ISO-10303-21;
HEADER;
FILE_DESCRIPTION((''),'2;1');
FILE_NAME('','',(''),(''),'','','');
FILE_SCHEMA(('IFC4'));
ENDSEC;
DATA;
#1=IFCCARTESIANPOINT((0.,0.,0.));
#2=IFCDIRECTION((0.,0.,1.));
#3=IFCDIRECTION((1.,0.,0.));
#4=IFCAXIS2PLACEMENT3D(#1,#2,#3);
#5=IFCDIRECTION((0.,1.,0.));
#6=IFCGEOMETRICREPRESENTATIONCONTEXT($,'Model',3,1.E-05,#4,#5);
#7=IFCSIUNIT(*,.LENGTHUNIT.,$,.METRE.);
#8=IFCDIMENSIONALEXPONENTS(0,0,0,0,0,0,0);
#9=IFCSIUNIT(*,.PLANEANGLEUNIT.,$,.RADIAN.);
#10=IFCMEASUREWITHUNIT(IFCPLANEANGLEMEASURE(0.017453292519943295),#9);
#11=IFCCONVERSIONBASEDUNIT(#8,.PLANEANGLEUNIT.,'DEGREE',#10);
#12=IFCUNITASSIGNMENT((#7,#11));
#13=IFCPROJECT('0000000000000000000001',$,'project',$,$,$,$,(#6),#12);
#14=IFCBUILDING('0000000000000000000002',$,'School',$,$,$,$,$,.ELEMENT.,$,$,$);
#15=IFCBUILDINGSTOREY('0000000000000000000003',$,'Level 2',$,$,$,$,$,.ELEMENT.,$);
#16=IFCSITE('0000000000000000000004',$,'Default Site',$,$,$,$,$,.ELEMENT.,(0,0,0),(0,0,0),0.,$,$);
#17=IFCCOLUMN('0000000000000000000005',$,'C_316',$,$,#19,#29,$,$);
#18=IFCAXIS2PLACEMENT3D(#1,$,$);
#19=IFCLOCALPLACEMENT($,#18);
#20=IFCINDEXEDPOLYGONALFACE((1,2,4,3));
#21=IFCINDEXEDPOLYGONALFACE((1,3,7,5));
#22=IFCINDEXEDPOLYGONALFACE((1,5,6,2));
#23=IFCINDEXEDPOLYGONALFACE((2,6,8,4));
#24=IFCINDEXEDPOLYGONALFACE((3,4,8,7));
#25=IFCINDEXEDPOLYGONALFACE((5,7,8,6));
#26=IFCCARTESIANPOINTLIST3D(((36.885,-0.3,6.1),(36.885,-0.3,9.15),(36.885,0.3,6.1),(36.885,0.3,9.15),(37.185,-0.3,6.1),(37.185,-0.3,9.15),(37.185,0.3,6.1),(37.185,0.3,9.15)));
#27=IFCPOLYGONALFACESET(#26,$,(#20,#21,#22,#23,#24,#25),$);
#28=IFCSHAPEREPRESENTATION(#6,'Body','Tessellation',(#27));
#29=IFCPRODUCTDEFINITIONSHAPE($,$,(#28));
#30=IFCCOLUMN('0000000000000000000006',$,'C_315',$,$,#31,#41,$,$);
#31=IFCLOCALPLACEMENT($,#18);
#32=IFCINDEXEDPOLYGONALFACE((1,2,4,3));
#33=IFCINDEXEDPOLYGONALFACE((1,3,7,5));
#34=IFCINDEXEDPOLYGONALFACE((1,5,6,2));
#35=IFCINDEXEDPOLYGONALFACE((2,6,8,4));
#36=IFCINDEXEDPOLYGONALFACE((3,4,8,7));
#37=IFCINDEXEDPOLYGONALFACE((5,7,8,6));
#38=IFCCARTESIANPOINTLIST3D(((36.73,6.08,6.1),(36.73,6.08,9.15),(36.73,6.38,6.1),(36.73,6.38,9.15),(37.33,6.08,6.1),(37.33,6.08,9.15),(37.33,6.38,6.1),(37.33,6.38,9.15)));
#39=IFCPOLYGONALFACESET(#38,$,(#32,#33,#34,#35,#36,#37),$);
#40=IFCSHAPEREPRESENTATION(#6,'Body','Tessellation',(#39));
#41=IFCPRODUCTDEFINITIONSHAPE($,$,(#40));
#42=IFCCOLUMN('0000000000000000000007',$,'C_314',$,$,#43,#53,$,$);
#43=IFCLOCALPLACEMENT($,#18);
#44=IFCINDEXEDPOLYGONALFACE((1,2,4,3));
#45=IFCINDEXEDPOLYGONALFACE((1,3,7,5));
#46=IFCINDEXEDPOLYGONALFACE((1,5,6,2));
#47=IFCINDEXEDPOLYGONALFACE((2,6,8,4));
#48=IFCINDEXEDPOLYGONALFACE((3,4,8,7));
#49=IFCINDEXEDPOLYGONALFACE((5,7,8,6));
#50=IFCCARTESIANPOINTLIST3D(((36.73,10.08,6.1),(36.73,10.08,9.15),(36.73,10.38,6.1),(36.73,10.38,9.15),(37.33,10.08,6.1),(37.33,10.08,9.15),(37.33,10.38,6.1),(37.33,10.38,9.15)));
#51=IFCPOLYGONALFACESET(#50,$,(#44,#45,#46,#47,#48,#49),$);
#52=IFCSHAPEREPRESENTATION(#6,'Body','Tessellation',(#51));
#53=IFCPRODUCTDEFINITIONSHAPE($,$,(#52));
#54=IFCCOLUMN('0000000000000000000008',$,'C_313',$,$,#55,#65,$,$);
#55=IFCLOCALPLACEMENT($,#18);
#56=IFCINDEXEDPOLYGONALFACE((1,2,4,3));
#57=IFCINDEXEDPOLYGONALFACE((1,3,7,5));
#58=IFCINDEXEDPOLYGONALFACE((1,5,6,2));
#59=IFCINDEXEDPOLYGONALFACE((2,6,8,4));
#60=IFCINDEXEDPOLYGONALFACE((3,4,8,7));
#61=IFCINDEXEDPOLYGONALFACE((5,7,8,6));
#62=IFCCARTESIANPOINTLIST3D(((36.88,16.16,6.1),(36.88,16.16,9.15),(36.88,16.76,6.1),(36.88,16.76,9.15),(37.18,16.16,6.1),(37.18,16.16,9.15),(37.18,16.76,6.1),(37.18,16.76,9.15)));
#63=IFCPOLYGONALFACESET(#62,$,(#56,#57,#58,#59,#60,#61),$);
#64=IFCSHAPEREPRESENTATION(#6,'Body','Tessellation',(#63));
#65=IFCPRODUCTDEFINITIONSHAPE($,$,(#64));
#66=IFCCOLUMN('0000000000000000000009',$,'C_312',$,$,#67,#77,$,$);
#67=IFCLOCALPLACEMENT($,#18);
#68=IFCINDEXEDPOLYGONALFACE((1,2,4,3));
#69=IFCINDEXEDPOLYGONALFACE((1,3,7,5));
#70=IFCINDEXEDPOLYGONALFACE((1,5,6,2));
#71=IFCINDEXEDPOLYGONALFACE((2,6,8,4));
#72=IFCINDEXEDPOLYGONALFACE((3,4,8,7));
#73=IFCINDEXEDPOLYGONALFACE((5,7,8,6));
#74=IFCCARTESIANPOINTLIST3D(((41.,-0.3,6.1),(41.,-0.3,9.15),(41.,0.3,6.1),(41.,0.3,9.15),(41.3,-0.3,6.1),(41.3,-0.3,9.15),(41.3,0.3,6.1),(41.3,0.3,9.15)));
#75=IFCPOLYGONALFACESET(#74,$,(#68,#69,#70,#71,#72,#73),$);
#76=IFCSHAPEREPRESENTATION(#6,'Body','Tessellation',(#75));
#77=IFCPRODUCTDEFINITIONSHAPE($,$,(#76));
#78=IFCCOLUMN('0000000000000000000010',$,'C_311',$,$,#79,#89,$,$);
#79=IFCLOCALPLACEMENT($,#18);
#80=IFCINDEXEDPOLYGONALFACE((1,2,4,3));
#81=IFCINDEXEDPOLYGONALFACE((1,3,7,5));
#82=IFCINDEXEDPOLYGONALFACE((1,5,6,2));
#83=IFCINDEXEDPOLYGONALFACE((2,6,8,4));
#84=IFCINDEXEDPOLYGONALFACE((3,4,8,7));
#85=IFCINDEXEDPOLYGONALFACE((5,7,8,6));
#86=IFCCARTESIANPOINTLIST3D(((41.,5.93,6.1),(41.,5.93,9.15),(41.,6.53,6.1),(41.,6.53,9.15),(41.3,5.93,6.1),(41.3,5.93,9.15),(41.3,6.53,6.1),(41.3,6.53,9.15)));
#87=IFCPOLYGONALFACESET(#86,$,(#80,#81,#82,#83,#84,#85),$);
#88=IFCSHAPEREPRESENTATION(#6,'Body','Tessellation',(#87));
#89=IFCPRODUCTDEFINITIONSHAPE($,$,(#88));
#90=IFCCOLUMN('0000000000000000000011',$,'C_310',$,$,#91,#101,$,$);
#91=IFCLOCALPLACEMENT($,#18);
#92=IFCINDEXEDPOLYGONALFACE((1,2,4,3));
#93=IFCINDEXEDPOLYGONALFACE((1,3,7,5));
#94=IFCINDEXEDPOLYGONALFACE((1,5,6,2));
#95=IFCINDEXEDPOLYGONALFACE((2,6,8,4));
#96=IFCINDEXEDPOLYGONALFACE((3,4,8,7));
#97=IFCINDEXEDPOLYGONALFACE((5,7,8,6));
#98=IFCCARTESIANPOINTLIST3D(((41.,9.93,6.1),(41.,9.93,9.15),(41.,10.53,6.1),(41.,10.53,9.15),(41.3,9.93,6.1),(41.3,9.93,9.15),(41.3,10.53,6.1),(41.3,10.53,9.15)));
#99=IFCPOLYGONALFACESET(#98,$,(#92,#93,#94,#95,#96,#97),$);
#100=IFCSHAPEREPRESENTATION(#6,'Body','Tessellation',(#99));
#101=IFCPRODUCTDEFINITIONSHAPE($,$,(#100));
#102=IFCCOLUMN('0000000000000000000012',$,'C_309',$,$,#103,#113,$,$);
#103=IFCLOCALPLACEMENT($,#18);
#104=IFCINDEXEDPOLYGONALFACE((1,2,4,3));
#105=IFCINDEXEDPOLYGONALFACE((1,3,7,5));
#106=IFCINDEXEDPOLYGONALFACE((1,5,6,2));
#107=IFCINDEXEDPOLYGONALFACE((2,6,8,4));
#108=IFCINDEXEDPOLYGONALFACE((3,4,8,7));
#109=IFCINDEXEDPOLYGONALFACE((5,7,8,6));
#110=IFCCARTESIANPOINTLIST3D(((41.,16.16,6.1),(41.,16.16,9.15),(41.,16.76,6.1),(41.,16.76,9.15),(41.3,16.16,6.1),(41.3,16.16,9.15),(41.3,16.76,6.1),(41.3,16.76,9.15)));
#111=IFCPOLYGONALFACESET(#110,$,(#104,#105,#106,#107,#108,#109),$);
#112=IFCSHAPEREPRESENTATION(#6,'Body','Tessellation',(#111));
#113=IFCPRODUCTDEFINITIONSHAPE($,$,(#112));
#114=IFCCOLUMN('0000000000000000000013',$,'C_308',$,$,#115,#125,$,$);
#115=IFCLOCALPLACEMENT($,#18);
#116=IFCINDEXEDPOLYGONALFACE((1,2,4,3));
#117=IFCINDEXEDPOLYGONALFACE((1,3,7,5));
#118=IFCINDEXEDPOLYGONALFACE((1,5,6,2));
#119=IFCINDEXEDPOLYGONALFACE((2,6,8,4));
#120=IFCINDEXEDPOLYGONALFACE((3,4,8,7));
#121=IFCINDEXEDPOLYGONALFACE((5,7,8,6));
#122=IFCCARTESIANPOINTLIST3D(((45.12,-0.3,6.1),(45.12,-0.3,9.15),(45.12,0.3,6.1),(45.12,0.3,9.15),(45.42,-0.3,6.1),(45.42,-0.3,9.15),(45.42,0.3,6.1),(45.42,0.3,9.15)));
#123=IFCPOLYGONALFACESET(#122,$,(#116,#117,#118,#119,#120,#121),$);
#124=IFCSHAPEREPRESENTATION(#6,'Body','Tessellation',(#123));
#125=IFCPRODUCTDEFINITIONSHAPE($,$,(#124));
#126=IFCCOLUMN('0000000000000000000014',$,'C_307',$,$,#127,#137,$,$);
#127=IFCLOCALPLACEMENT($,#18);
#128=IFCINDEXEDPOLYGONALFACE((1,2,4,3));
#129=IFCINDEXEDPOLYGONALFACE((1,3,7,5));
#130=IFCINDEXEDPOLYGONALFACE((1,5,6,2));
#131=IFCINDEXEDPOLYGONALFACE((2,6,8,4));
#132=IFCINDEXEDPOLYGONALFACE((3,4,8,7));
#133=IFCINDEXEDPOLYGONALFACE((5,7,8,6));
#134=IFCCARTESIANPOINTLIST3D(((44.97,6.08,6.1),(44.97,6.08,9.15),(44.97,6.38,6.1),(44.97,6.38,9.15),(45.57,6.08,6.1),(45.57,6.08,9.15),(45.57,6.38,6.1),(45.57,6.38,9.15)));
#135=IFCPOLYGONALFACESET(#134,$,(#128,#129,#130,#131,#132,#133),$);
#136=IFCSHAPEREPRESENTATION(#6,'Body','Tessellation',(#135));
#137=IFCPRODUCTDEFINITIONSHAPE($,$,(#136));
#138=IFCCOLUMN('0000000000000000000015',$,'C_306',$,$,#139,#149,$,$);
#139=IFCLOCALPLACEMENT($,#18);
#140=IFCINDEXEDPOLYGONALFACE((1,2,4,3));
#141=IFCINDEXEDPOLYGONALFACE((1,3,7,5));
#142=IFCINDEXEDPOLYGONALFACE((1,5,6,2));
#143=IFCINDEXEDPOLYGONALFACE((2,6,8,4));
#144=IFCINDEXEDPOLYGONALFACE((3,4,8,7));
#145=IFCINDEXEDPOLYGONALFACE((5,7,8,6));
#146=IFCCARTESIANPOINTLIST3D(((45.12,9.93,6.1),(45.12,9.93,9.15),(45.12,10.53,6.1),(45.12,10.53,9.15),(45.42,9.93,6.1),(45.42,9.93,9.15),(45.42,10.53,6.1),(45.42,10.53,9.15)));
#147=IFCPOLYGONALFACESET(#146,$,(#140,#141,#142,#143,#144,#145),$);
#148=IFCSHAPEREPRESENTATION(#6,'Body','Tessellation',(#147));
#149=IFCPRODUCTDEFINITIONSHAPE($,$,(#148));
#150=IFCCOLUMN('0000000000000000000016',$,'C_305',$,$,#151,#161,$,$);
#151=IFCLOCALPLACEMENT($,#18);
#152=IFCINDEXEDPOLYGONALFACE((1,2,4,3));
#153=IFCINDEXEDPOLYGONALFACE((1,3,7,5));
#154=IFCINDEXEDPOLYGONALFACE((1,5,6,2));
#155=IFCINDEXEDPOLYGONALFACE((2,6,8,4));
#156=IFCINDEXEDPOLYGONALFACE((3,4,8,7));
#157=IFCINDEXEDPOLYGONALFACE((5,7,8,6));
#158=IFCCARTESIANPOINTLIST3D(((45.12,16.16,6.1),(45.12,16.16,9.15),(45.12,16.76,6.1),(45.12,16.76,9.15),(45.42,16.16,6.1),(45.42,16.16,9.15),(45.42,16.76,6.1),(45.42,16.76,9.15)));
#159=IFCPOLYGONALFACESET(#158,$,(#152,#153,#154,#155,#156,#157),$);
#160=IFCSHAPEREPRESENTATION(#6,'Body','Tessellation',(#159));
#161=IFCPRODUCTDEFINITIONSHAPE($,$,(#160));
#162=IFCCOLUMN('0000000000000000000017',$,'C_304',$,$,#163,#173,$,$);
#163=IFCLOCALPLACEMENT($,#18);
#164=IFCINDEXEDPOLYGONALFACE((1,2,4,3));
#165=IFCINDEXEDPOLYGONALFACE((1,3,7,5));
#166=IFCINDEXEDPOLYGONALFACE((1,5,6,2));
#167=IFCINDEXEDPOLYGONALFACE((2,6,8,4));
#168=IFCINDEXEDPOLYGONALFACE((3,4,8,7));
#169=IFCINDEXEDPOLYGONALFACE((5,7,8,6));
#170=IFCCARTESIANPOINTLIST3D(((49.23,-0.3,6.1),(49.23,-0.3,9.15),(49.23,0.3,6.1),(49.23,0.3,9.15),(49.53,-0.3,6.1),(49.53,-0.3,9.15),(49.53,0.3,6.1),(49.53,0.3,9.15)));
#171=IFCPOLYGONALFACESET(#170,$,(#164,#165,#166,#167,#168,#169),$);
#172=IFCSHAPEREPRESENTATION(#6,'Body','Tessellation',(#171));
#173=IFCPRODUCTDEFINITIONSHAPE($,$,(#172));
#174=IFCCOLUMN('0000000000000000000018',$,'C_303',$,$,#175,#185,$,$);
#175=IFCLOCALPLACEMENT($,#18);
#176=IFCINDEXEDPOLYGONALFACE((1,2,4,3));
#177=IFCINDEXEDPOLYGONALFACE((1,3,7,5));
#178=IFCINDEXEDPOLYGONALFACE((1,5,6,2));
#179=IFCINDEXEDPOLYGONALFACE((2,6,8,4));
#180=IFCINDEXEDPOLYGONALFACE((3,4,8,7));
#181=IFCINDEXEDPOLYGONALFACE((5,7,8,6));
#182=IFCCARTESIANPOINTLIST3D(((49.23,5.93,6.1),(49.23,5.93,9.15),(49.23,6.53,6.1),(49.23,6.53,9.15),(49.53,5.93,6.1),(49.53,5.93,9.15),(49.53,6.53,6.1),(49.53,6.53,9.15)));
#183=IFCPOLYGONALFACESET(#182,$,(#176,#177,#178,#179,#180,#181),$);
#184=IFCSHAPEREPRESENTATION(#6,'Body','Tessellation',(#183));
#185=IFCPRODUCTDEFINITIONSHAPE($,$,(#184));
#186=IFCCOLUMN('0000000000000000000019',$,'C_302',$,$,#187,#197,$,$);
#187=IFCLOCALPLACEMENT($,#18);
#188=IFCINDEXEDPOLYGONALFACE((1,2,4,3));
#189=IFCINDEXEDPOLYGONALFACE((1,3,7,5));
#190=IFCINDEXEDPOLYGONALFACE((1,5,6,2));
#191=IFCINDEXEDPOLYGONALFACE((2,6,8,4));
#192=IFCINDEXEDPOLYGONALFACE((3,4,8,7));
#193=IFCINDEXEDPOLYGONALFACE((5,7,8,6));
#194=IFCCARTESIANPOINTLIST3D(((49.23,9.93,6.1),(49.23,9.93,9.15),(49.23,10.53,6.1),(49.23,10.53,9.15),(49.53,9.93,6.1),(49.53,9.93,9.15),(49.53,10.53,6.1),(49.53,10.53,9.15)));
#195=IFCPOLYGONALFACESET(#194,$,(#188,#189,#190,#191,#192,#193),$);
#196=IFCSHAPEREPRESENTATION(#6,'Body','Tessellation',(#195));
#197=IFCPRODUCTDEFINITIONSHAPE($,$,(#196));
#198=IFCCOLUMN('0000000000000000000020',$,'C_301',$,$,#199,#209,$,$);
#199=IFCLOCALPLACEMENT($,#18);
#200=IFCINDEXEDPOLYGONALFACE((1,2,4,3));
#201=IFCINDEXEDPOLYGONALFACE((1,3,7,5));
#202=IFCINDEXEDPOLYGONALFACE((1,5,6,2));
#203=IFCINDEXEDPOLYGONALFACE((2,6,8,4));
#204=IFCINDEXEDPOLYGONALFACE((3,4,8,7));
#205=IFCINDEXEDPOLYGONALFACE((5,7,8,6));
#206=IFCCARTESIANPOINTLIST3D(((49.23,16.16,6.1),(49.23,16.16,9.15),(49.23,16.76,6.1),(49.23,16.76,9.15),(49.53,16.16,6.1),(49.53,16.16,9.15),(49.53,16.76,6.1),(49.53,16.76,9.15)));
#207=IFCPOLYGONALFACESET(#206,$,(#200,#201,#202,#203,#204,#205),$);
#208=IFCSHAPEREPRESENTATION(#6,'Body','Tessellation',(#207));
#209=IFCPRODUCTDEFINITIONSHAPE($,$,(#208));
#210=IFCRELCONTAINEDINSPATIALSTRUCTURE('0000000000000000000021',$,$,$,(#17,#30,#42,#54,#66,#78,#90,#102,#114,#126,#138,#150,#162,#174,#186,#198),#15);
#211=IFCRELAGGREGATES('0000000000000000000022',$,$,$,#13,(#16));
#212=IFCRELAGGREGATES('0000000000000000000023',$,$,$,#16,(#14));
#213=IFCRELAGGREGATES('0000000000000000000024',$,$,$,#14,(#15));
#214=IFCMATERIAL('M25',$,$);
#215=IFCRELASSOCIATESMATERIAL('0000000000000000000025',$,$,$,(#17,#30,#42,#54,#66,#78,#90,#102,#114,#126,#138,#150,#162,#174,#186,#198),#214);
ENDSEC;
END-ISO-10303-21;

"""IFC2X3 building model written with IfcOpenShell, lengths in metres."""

from ifc_helpers import new_model, entity, si_unit, converted_unit, direction, frame, frame_2d, origin_with_axes, place, context, project, spatial, rectangle, extrude, material, element, save


model = new_model("IFC2X3")

# Units and contexts
model_context = context("Model", 3, precision=1e-05, world=origin_with_axes(), true_north=direction((0.0, 1.0, 0.0)))
ifc_project = project(units=[si_unit("LENGTHUNIT", "METRE"), converted_unit("PLANEANGLEUNIT", "DEGREE", entity("IfcPlaneAngleMeasure", 0.017453292519943295), si_unit("PLANEANGLEUNIT", "RADIAN"), dimensions=[0, 0, 0, 0, 0, 0, 0])], contexts=[model_context])

# Site, building, storey
site = spatial("IfcSite", under=ifc_project, Name="Default Site", CompositionType="ELEMENT", RefLatitude=(0, 0, 0), RefLongitude=(0, 0, 0), RefElevation=0.0)
building = spatial("IfcBuilding", under=site, Name="School", CompositionType="ELEMENT")
storey = spatial("IfcBuildingStorey", under=building, Name="Level 2", CompositionType="ELEMENT")

# Columns
ifc_material = material(Name="M25")
placement = place(None, origin_with_axes())
element("IfcColumn", 1, at=placement, inside=storey, material=ifc_material, Name="C_316", context=model_context, shape_type="SweptSolid", body=[
    extrude(rectangle(XDim=0.3, YDim=0.6, at=frame_2d((0.0, 0.0), x_axis=(1.0, 0.0, 0.0))), frame((37.035, 0.0, 6.1), z_axis=(0.0, 0.0, 1.0), x_axis=(1.0, 0.0, 0.0)), (0.0, 0.0, 1.0), 3.05),
])
element("IfcColumn", 2, at=placement, inside=storey, material=ifc_material, Name="C_315", context=model_context, shape_type="SweptSolid", body=[
    extrude(rectangle(XDim=0.6, YDim=0.3, at=frame_2d((0.0, 0.0), x_axis=(1.0, 0.0, 0.0))), frame((37.03, 6.23, 6.1), z_axis=(0.0, 0.0, 1.0), x_axis=(1.0, 0.0, 0.0)), (0.0, 0.0, 1.0), 3.05),
])
element("IfcColumn", 3, at=placement, inside=storey, material=ifc_material, Name="C_314", context=model_context, shape_type="SweptSolid", body=[
    extrude(rectangle(XDim=0.6, YDim=0.3, at=frame_2d((0.0, 0.0), x_axis=(1.0, 0.0, 0.0))), frame((37.03, 10.23, 6.1), z_axis=(0.0, 0.0, 1.0), x_axis=(1.0, 0.0, 0.0)), (0.0, 0.0, 1.0), 3.05),
])
element("IfcColumn", 4, at=placement, inside=storey, material=ifc_material, Name="C_313", context=model_context, shape_type="SweptSolid", body=[
    extrude(rectangle(XDim=0.3, YDim=0.6, at=frame_2d((0.0, 0.0), x_axis=(1.0, 0.0, 0.0))), frame((37.03, 16.46, 6.1), z_axis=(0.0, 0.0, 1.0), x_axis=(1.0, 0.0, 0.0)), (0.0, 0.0, 1.0), 3.05),
])
element("IfcColumn", 5, at=placement, inside=storey, material=ifc_material, Name="C_312", context=model_context, shape_type="SweptSolid", body=[
    extrude(rectangle(XDim=0.3, YDim=0.6, at=frame_2d((0.0, 0.0), x_axis=(1.0, 0.0, 0.0))), frame((41.15, 0.0, 6.1), z_axis=(0.0, 0.0, 1.0), x_axis=(1.0, 0.0, 0.0)), (0.0, 0.0, 1.0), 3.05),
])
element("IfcColumn", 6, at=placement, inside=storey, material=ifc_material, Name="C_311", context=model_context, shape_type="SweptSolid", body=[
    extrude(rectangle(XDim=0.3, YDim=0.6, at=frame_2d((0.0, 0.0), x_axis=(1.0, 0.0, 0.0))), frame((41.15, 6.23, 6.1), z_axis=(0.0, 0.0, 1.0), x_axis=(1.0, 0.0, 0.0)), (0.0, 0.0, 1.0), 3.05),
])
element("IfcColumn", 7, at=placement, inside=storey, material=ifc_material, Name="C_310", context=model_context, shape_type="SweptSolid", body=[
    extrude(rectangle(XDim=0.3, YDim=0.6, at=frame_2d((0.0, 0.0), x_axis=(1.0, 0.0, 0.0))), frame((41.15, 10.23, 6.1), z_axis=(0.0, 0.0, 1.0), x_axis=(1.0, 0.0, 0.0)), (0.0, 0.0, 1.0), 3.05),
])
element("IfcColumn", 8, at=placement, inside=storey, material=ifc_material, Name="C_309", context=model_context, shape_type="SweptSolid", body=[
    extrude(rectangle(XDim=0.3, YDim=0.6, at=frame_2d((0.0, 0.0), x_axis=(1.0, 0.0, 0.0))), frame((41.15, 16.46, 6.1), z_axis=(0.0, 0.0, 1.0), x_axis=(1.0, 0.0, 0.0)), (0.0, 0.0, 1.0), 3.05),
])
element("IfcColumn", 9, at=placement, inside=storey, material=ifc_material, Name="C_308", context=model_context, shape_type="SweptSolid", body=[
    extrude(rectangle(XDim=0.3, YDim=0.6, at=frame_2d((0.0, 0.0), x_axis=(1.0, 0.0, 0.0))), frame((45.27, 0.0, 6.1), z_axis=(0.0, 0.0, 1.0), x_axis=(1.0, 0.0, 0.0)), (0.0, 0.0, 1.0), 3.05),
])
element("IfcColumn", 10, at=placement, inside=storey, material=ifc_material, Name="C_307", context=model_context, shape_type="SweptSolid", body=[
    extrude(rectangle(XDim=0.6, YDim=0.3, at=frame_2d((0.0, 0.0), x_axis=(1.0, 0.0, 0.0))), frame((45.27, 6.23, 6.1), z_axis=(0.0, 0.0, 1.0), x_axis=(1.0, 0.0, 0.0)), (0.0, 0.0, 1.0), 3.05),
])
element("IfcColumn", 11, at=placement, inside=storey, material=ifc_material, Name="C_306", context=model_context, shape_type="SweptSolid", body=[
    extrude(rectangle(XDim=0.3, YDim=0.6, at=frame_2d((0.0, 0.0), x_axis=(1.0, 0.0, 0.0))), frame((45.27, 10.23, 6.1), z_axis=(0.0, 0.0, 1.0), x_axis=(1.0, 0.0, 0.0)), (0.0, 0.0, 1.0), 3.05),
])
element("IfcColumn", 12, at=placement, inside=storey, material=ifc_material, Name="C_305", context=model_context, shape_type="SweptSolid", body=[
    extrude(rectangle(XDim=0.3, YDim=0.6, at=frame_2d((0.0, 0.0), x_axis=(1.0, 0.0, 0.0))), frame((45.27, 16.46, 6.1), z_axis=(0.0, 0.0, 1.0), x_axis=(1.0, 0.0, 0.0)), (0.0, 0.0, 1.0), 3.05),
])
element("IfcColumn", 13, at=placement, inside=storey, material=ifc_material, Name="C_304", context=model_context, shape_type="SweptSolid", body=[
    extrude(rectangle(XDim=0.3, YDim=0.6, at=frame_2d((0.0, 0.0), x_axis=(1.0, 0.0, 0.0))), frame((49.38, 0.0, 6.1), z_axis=(0.0, 0.0, 1.0), x_axis=(1.0, 0.0, 0.0)), (0.0, 0.0, 1.0), 3.05),
])
element("IfcColumn", 14, at=placement, inside=storey, material=ifc_material, Name="C_303", context=model_context, shape_type="SweptSolid", body=[
    extrude(rectangle(XDim=0.3, YDim=0.6, at=frame_2d((0.0, 0.0), x_axis=(1.0, 0.0, 0.0))), frame((49.38, 6.23, 6.1), z_axis=(0.0, 0.0, 1.0), x_axis=(1.0, 0.0, 0.0)), (0.0, 0.0, 1.0), 3.05),
])
element("IfcColumn", 15, at=placement, inside=storey, material=ifc_material, Name="C_302", context=model_context, shape_type="SweptSolid", body=[
    extrude(rectangle(XDim=0.3, YDim=0.6, at=frame_2d((0.0, 0.0), x_axis=(1.0, 0.0, 0.0))), frame((49.38, 10.23, 6.1), z_axis=(0.0, 0.0, 1.0), x_axis=(1.0, 0.0, 0.0)), (0.0, 0.0, 1.0), 3.05),
])
element("IfcColumn", 16, at=placement, inside=storey, material=ifc_material, Name="C_301", context=model_context, shape_type="SweptSolid", body=[
    extrude(rectangle(XDim=0.3, YDim=0.6, at=frame_2d((0.0, 0.0), x_axis=(1.0, 0.0, 0.0))), frame((49.38, 16.46, 6.1), z_axis=(0.0, 0.0, 1.0), x_axis=(1.0, 0.0, 0.0)), (0.0, 0.0, 1.0), 3.05),
])

save(model, "model.ifc")
